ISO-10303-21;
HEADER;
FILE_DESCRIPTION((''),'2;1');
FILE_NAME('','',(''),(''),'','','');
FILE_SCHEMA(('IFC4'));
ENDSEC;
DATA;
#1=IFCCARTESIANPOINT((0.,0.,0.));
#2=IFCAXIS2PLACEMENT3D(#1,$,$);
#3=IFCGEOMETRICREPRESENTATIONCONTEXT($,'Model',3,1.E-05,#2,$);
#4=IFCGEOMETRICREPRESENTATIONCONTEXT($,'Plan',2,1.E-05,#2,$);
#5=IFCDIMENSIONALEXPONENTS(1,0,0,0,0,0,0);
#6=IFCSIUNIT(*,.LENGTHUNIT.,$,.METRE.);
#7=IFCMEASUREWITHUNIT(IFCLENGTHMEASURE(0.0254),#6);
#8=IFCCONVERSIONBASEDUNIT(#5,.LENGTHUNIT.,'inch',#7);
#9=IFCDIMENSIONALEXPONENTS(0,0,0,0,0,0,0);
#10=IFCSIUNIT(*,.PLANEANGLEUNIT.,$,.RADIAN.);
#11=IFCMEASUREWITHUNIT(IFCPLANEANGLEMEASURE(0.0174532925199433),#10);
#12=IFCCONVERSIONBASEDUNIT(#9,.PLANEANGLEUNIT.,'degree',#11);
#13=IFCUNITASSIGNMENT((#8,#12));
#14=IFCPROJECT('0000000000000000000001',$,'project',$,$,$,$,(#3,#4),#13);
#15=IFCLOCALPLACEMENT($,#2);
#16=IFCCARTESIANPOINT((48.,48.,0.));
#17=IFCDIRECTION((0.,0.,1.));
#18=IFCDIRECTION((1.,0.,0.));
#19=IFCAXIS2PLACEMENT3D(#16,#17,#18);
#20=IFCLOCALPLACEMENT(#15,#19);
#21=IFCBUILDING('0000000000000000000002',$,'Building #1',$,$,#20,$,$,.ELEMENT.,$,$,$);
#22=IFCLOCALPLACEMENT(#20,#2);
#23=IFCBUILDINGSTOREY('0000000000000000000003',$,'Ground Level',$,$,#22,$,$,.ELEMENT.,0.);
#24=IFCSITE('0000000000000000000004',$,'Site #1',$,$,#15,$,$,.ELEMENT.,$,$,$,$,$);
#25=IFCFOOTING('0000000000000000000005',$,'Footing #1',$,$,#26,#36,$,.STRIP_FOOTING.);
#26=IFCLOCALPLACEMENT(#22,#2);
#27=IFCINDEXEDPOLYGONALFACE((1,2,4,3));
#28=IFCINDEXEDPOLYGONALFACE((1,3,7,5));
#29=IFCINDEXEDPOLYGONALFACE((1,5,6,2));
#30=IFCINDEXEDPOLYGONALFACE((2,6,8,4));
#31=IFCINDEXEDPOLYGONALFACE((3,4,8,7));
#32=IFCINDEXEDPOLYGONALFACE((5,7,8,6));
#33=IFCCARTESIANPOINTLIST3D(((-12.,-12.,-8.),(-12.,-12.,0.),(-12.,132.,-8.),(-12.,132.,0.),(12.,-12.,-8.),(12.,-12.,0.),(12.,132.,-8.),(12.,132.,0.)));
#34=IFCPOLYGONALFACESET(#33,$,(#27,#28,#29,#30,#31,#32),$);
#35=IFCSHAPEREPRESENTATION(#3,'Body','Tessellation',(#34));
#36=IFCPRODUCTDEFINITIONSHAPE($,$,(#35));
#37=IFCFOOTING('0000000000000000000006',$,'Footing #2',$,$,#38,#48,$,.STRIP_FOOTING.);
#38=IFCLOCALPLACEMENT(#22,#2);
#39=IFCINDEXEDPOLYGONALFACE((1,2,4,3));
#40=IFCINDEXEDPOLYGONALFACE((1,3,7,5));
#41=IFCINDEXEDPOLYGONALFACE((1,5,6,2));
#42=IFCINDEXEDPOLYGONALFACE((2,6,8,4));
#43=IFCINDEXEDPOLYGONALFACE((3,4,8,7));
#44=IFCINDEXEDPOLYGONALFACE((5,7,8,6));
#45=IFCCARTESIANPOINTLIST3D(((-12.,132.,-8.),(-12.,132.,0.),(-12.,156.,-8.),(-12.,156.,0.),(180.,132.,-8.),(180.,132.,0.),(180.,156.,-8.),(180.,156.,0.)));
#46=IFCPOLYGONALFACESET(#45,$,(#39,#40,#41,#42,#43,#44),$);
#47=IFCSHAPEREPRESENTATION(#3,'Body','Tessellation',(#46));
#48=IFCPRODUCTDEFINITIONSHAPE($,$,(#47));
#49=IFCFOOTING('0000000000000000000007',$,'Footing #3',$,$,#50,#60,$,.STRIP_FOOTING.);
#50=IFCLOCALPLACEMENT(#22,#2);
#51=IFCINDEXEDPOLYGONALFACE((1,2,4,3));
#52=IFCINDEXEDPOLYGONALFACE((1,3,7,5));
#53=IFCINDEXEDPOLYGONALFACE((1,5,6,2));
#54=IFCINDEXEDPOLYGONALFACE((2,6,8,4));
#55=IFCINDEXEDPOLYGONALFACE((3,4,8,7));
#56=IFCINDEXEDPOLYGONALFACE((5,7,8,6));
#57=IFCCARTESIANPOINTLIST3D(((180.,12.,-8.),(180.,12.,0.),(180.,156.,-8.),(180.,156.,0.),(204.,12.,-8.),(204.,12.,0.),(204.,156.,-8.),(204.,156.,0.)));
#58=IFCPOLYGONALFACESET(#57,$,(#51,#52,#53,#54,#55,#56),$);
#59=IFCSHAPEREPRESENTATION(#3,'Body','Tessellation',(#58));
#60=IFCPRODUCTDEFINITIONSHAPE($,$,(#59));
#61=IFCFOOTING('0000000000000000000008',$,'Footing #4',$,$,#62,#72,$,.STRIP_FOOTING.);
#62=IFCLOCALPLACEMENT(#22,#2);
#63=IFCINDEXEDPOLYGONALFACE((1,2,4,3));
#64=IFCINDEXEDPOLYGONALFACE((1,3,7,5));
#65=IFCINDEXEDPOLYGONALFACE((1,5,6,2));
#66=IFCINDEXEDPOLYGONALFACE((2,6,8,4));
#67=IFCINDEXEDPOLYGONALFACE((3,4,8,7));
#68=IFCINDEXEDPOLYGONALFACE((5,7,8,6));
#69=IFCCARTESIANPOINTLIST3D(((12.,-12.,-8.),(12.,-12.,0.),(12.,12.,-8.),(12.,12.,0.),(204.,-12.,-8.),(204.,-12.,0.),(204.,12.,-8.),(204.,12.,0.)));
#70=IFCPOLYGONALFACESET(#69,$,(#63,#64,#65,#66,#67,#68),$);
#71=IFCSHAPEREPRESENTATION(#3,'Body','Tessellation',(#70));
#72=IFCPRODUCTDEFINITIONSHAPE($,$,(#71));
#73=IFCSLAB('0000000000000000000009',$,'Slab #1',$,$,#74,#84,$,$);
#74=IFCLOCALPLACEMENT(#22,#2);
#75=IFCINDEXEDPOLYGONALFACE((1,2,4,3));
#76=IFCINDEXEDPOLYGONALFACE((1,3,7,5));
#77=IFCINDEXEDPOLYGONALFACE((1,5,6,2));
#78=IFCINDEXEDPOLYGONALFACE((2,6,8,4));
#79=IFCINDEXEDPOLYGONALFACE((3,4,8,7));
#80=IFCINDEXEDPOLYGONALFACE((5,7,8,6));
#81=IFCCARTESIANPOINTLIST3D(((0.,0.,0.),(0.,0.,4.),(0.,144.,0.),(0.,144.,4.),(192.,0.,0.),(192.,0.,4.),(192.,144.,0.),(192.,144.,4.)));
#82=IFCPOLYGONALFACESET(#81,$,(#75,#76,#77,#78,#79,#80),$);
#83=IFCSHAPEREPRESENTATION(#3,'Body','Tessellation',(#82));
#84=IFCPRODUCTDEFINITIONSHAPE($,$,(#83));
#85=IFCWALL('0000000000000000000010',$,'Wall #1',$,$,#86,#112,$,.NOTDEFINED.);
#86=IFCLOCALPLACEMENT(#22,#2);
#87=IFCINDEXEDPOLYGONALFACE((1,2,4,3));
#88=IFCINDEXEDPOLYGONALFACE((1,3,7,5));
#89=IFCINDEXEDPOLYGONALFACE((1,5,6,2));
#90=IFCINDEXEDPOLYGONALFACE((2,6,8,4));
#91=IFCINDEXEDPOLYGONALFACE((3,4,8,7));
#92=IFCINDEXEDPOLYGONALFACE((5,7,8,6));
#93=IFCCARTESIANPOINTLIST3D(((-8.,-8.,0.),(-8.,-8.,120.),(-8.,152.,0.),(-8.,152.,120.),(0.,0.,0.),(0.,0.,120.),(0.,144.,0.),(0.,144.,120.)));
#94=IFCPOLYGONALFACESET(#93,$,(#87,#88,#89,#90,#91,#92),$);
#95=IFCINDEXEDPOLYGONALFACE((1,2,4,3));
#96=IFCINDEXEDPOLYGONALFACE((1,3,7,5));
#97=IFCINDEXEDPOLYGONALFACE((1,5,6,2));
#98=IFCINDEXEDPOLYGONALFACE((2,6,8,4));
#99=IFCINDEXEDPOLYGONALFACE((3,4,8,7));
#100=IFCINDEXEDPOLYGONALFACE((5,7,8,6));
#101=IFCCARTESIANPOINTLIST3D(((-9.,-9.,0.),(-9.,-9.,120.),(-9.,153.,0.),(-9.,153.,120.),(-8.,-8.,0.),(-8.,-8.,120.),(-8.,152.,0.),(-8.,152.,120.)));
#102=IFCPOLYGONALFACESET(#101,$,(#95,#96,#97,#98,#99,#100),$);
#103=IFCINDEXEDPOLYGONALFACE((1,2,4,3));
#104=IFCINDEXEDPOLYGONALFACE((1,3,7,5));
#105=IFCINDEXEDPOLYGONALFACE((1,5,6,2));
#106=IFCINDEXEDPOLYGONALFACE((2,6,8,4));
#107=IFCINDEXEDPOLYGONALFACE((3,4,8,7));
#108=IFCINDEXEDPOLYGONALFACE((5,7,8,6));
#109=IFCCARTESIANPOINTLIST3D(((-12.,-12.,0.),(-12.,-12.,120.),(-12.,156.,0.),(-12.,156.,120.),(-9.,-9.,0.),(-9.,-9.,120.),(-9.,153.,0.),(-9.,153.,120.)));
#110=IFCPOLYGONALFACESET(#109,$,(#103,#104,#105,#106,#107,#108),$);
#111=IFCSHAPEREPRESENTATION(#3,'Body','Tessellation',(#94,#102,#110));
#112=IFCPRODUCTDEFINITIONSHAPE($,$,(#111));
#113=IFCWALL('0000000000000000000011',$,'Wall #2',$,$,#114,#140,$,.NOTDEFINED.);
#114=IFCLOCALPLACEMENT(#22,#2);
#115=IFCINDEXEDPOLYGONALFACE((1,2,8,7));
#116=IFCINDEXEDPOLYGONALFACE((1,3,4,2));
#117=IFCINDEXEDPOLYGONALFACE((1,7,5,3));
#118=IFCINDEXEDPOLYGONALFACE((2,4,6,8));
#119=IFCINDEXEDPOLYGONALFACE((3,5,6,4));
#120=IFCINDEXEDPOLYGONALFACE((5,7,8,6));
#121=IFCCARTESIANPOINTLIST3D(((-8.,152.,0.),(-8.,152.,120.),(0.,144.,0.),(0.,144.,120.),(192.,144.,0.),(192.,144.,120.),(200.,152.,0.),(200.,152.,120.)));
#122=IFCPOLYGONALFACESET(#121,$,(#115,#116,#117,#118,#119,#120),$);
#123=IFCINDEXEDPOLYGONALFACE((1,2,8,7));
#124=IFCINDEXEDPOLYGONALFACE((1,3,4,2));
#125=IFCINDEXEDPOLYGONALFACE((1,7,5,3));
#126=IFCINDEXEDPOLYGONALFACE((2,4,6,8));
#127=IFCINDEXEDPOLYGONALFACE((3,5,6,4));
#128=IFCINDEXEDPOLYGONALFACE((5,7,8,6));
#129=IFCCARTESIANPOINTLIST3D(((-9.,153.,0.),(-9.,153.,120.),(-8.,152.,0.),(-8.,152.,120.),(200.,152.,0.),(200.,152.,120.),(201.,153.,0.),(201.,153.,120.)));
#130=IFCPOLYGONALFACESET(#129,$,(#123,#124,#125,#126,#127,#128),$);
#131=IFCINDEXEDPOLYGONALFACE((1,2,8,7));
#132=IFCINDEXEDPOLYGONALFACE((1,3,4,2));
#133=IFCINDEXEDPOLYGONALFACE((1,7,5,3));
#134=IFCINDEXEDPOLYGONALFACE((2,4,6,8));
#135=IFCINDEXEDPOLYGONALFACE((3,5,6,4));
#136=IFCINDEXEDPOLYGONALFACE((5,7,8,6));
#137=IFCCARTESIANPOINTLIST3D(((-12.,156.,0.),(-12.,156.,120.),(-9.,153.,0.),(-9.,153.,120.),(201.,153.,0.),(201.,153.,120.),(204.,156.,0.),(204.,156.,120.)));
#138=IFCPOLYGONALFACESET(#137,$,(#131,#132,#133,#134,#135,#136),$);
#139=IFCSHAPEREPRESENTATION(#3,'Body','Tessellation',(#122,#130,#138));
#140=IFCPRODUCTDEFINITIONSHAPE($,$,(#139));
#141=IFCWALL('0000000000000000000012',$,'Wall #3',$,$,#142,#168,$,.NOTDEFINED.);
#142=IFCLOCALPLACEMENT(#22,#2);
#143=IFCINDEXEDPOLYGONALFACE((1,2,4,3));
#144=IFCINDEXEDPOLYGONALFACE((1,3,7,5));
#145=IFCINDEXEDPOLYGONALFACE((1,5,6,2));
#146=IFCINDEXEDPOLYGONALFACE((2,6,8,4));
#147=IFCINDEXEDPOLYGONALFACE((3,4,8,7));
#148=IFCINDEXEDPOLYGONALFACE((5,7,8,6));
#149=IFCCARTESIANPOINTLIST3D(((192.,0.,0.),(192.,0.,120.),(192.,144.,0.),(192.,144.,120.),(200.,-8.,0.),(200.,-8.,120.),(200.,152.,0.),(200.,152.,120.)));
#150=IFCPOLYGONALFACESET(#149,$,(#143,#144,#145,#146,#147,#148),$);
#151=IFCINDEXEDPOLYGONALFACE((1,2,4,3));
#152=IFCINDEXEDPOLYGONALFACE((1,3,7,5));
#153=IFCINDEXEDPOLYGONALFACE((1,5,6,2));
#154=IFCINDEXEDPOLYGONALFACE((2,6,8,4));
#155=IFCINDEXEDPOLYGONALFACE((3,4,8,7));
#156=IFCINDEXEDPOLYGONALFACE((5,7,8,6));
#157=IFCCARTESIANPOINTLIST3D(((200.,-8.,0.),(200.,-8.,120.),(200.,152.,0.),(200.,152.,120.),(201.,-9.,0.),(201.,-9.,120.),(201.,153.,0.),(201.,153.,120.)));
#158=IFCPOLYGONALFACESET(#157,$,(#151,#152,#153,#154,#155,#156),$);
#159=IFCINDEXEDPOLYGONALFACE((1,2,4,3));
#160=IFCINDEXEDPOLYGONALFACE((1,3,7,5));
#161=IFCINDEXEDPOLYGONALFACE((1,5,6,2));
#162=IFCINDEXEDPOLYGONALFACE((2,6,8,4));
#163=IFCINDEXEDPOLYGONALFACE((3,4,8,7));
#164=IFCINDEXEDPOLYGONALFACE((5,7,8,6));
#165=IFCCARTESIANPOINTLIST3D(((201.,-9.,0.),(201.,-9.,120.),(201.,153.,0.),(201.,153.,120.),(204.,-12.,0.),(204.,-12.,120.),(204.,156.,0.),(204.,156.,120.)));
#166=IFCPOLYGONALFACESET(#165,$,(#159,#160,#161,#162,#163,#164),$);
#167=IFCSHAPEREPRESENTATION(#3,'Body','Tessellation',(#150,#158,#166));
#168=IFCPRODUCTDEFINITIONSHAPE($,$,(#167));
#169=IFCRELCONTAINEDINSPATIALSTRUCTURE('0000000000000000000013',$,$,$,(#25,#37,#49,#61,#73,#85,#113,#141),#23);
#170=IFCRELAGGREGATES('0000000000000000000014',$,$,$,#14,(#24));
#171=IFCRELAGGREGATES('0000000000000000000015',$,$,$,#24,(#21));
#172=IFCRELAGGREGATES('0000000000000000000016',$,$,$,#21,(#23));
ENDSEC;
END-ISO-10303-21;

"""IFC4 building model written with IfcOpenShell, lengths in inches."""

from ifc_helpers import new_model, entity, si_unit, converted_unit, frame, origin, place, context, project, spatial, polyline, rectangle, outline, extrude, element, save


model = new_model("IFC4")

# Units and contexts
model_context = context("Model", 3, precision=1e-05, world=origin())
plan_context = context("Plan", 2, precision=1e-05, world=origin())
ifc_project = project(units=[converted_unit("LENGTHUNIT", "inch", entity("IfcLengthMeasure", 0.0254), si_unit("LENGTHUNIT", "METRE"), dimensions=[1, 0, 0, 0, 0, 0, 0]), converted_unit("PLANEANGLEUNIT", "degree", entity("IfcPlaneAngleMeasure", 0.0174532925199433), si_unit("PLANEANGLEUNIT", "RADIAN"), dimensions=[0, 0, 0, 0, 0, 0, 0])], contexts=[model_context, plan_context])

# Site, building, storey
site_placement = place(None, origin())
site = spatial("IfcSite", under=ifc_project, at=site_placement, Name="Site #1", CompositionType="ELEMENT")
building_placement = place(site_placement, frame((48.0, 48.0, 0.0), z_axis=(0.0, 0.0, 1.0), x_axis=(1.0, 0.0, 0.0)))
building = spatial("IfcBuilding", under=site, at=building_placement, Name="Building #1", CompositionType="ELEMENT")
storey_placement = place(building_placement, origin())
storey = spatial("IfcBuildingStorey", under=building, at=storey_placement, Name="Ground Level", CompositionType="ELEMENT", Elevation=0.0)

# Footings
footing_1_placement = place(storey_placement, frame((0.0, 0.0, 0.0), z_axis=(0.0, 0.0, 1.0), x_axis=(0.0, 1.0, 0.0)))
element("IfcFooting", 1, at=footing_1_placement, inside=storey, Name="Footing #1", PredefinedType="STRIP_FOOTING", context=model_context, shape_type="SweptSolid", body=[
    extrude(rectangle(XDim=24.0, YDim=8.0), frame((-12.0, 0.0, -4.0), z_axis=(1.0, 0.0, 0.0), x_axis=(0.0, 1.0, 0.0)), (0.0, 0.0, 1.0), 144.0),
])
footing_2_placement = place(storey_placement, frame((0.0, 144.0, 0.0), z_axis=(0.0, 0.0, 1.0), x_axis=(1.0, 0.0, 0.0)))
element("IfcFooting", 2, at=footing_2_placement, inside=storey, Name="Footing #2", PredefinedType="STRIP_FOOTING", context=model_context, shape_type="SweptSolid", body=[
    extrude(rectangle(XDim=24.0, YDim=8.0), frame((-12.0, 0.0, -4.0), z_axis=(1.0, 0.0, 0.0), x_axis=(0.0, 1.0, 0.0)), (0.0, 0.0, 1.0), 192.0),
])
footing_3_placement = place(storey_placement, frame((192.0, 144.0, 0.0), z_axis=(0.0, 0.0, 1.0), x_axis=(0.0, -1.0, 0.0)))
element("IfcFooting", 3, at=footing_3_placement, inside=storey, Name="Footing #3", PredefinedType="STRIP_FOOTING", context=model_context, shape_type="SweptSolid", body=[
    extrude(rectangle(XDim=24.0, YDim=8.0), frame((-12.0, 0.0, -4.0), z_axis=(1.0, 0.0, 0.0), x_axis=(0.0, 1.0, 0.0)), (0.0, 0.0, 1.0), 144.0),
])
footing_4_placement = place(storey_placement, frame((192.0, 0.0, 0.0), z_axis=(0.0, 0.0, 1.0), x_axis=(-1.0, 0.0, 0.0)))
element("IfcFooting", 4, at=footing_4_placement, inside=storey, Name="Footing #4", PredefinedType="STRIP_FOOTING", context=model_context, shape_type="SweptSolid", body=[
    extrude(rectangle(XDim=24.0, YDim=8.0), frame((-12.0, 0.0, -4.0), z_axis=(1.0, 0.0, 0.0), x_axis=(0.0, 1.0, 0.0)), (0.0, 0.0, 1.0), 192.0),
])

# Slab
slab_placement = place(storey_placement, origin())
element("IfcSlab", 5, at=slab_placement, inside=storey, Name="Slab #1", context=model_context, shape_type="SweptSolid", body=[
    extrude(outline(polyline([(0.0, 0.0), (192.0, 0.0), (192.0, 144.0), (0.0, 144.0), (0.0, 0.0)])), origin(), (0.0, 0.0, 1.0), 4.0),
])

# Walls
wall_1_placement = place(storey_placement, frame((0.0, 0.0, 0.0), z_axis=(0.0, 0.0, 1.0), x_axis=(0.0, 1.0, 0.0)))
element("IfcWall", 6, at=wall_1_placement, inside=storey, Name="Wall #1", PredefinedType="NOTDEFINED", context=model_context, shape_type="SweptSolid", body=[
    extrude(outline(polyline([(0.0, 0.0), (144.0, 0.0), (152.0, 8.0), (-8.0, 8.0), (0.0, 0.0)])), origin(), (0.0, 0.0, 1.0), 120.0),
    extrude(outline(polyline([(-8.0, 8.0), (152.0, 8.0), (153.0, 9.0), (-9.0, 9.0), (-8.0, 8.0)])), origin(), (0.0, 0.0, 1.0), 120.0),
    extrude(outline(polyline([(-9.0, 9.0), (153.0, 9.0), (156.0, 12.0), (-12.0, 12.0), (-9.0, 9.0)])), origin(), (0.0, 0.0, 1.0), 120.0),
])
wall_2_placement = place(storey_placement, frame((0.0, 144.0, 0.0), z_axis=(0.0, 0.0, 1.0), x_axis=(1.0, 0.0, 0.0)))
element("IfcWall", 7, at=wall_2_placement, inside=storey, Name="Wall #2", PredefinedType="NOTDEFINED", context=model_context, shape_type="SweptSolid", body=[
    extrude(outline(polyline([(0.0, 0.0), (192.0, 0.0), (200.0, 8.0), (-8.0, 8.0), (0.0, 0.0)])), origin(), (0.0, 0.0, 1.0), 120.0),
    extrude(outline(polyline([(-8.0, 8.0), (200.0, 8.0), (201.0, 9.0), (-9.0, 9.0), (-8.0, 8.0)])), origin(), (0.0, 0.0, 1.0), 120.0),
    extrude(outline(polyline([(-9.0, 9.0), (201.0, 9.0), (204.0, 12.0), (-12.0, 12.0), (-9.0, 9.0)])), origin(), (0.0, 0.0, 1.0), 120.0),
])
wall_3_placement = place(storey_placement, frame((192.0, 144.0, 0.0), z_axis=(0.0, 0.0, 1.0), x_axis=(0.0, -1.0, 0.0)))
element("IfcWall", 8, at=wall_3_placement, inside=storey, Name="Wall #3", PredefinedType="NOTDEFINED", context=model_context, shape_type="SweptSolid", body=[
    extrude(outline(polyline([(0.0, 0.0), (144.0, 0.0), (152.0, 8.0), (-8.0, 8.0), (0.0, 0.0)])), origin(), (0.0, 0.0, 1.0), 120.0),
    extrude(outline(polyline([(-8.0, 8.0), (152.0, 8.0), (153.0, 9.0), (-9.0, 9.0), (-8.0, 8.0)])), origin(), (0.0, 0.0, 1.0), 120.0),
    extrude(outline(polyline([(-9.0, 9.0), (153.0, 9.0), (156.0, 12.0), (-12.0, 12.0), (-9.0, 9.0)])), origin(), (0.0, 0.0, 1.0), 120.0),
])

save(model, "model.ifc")
